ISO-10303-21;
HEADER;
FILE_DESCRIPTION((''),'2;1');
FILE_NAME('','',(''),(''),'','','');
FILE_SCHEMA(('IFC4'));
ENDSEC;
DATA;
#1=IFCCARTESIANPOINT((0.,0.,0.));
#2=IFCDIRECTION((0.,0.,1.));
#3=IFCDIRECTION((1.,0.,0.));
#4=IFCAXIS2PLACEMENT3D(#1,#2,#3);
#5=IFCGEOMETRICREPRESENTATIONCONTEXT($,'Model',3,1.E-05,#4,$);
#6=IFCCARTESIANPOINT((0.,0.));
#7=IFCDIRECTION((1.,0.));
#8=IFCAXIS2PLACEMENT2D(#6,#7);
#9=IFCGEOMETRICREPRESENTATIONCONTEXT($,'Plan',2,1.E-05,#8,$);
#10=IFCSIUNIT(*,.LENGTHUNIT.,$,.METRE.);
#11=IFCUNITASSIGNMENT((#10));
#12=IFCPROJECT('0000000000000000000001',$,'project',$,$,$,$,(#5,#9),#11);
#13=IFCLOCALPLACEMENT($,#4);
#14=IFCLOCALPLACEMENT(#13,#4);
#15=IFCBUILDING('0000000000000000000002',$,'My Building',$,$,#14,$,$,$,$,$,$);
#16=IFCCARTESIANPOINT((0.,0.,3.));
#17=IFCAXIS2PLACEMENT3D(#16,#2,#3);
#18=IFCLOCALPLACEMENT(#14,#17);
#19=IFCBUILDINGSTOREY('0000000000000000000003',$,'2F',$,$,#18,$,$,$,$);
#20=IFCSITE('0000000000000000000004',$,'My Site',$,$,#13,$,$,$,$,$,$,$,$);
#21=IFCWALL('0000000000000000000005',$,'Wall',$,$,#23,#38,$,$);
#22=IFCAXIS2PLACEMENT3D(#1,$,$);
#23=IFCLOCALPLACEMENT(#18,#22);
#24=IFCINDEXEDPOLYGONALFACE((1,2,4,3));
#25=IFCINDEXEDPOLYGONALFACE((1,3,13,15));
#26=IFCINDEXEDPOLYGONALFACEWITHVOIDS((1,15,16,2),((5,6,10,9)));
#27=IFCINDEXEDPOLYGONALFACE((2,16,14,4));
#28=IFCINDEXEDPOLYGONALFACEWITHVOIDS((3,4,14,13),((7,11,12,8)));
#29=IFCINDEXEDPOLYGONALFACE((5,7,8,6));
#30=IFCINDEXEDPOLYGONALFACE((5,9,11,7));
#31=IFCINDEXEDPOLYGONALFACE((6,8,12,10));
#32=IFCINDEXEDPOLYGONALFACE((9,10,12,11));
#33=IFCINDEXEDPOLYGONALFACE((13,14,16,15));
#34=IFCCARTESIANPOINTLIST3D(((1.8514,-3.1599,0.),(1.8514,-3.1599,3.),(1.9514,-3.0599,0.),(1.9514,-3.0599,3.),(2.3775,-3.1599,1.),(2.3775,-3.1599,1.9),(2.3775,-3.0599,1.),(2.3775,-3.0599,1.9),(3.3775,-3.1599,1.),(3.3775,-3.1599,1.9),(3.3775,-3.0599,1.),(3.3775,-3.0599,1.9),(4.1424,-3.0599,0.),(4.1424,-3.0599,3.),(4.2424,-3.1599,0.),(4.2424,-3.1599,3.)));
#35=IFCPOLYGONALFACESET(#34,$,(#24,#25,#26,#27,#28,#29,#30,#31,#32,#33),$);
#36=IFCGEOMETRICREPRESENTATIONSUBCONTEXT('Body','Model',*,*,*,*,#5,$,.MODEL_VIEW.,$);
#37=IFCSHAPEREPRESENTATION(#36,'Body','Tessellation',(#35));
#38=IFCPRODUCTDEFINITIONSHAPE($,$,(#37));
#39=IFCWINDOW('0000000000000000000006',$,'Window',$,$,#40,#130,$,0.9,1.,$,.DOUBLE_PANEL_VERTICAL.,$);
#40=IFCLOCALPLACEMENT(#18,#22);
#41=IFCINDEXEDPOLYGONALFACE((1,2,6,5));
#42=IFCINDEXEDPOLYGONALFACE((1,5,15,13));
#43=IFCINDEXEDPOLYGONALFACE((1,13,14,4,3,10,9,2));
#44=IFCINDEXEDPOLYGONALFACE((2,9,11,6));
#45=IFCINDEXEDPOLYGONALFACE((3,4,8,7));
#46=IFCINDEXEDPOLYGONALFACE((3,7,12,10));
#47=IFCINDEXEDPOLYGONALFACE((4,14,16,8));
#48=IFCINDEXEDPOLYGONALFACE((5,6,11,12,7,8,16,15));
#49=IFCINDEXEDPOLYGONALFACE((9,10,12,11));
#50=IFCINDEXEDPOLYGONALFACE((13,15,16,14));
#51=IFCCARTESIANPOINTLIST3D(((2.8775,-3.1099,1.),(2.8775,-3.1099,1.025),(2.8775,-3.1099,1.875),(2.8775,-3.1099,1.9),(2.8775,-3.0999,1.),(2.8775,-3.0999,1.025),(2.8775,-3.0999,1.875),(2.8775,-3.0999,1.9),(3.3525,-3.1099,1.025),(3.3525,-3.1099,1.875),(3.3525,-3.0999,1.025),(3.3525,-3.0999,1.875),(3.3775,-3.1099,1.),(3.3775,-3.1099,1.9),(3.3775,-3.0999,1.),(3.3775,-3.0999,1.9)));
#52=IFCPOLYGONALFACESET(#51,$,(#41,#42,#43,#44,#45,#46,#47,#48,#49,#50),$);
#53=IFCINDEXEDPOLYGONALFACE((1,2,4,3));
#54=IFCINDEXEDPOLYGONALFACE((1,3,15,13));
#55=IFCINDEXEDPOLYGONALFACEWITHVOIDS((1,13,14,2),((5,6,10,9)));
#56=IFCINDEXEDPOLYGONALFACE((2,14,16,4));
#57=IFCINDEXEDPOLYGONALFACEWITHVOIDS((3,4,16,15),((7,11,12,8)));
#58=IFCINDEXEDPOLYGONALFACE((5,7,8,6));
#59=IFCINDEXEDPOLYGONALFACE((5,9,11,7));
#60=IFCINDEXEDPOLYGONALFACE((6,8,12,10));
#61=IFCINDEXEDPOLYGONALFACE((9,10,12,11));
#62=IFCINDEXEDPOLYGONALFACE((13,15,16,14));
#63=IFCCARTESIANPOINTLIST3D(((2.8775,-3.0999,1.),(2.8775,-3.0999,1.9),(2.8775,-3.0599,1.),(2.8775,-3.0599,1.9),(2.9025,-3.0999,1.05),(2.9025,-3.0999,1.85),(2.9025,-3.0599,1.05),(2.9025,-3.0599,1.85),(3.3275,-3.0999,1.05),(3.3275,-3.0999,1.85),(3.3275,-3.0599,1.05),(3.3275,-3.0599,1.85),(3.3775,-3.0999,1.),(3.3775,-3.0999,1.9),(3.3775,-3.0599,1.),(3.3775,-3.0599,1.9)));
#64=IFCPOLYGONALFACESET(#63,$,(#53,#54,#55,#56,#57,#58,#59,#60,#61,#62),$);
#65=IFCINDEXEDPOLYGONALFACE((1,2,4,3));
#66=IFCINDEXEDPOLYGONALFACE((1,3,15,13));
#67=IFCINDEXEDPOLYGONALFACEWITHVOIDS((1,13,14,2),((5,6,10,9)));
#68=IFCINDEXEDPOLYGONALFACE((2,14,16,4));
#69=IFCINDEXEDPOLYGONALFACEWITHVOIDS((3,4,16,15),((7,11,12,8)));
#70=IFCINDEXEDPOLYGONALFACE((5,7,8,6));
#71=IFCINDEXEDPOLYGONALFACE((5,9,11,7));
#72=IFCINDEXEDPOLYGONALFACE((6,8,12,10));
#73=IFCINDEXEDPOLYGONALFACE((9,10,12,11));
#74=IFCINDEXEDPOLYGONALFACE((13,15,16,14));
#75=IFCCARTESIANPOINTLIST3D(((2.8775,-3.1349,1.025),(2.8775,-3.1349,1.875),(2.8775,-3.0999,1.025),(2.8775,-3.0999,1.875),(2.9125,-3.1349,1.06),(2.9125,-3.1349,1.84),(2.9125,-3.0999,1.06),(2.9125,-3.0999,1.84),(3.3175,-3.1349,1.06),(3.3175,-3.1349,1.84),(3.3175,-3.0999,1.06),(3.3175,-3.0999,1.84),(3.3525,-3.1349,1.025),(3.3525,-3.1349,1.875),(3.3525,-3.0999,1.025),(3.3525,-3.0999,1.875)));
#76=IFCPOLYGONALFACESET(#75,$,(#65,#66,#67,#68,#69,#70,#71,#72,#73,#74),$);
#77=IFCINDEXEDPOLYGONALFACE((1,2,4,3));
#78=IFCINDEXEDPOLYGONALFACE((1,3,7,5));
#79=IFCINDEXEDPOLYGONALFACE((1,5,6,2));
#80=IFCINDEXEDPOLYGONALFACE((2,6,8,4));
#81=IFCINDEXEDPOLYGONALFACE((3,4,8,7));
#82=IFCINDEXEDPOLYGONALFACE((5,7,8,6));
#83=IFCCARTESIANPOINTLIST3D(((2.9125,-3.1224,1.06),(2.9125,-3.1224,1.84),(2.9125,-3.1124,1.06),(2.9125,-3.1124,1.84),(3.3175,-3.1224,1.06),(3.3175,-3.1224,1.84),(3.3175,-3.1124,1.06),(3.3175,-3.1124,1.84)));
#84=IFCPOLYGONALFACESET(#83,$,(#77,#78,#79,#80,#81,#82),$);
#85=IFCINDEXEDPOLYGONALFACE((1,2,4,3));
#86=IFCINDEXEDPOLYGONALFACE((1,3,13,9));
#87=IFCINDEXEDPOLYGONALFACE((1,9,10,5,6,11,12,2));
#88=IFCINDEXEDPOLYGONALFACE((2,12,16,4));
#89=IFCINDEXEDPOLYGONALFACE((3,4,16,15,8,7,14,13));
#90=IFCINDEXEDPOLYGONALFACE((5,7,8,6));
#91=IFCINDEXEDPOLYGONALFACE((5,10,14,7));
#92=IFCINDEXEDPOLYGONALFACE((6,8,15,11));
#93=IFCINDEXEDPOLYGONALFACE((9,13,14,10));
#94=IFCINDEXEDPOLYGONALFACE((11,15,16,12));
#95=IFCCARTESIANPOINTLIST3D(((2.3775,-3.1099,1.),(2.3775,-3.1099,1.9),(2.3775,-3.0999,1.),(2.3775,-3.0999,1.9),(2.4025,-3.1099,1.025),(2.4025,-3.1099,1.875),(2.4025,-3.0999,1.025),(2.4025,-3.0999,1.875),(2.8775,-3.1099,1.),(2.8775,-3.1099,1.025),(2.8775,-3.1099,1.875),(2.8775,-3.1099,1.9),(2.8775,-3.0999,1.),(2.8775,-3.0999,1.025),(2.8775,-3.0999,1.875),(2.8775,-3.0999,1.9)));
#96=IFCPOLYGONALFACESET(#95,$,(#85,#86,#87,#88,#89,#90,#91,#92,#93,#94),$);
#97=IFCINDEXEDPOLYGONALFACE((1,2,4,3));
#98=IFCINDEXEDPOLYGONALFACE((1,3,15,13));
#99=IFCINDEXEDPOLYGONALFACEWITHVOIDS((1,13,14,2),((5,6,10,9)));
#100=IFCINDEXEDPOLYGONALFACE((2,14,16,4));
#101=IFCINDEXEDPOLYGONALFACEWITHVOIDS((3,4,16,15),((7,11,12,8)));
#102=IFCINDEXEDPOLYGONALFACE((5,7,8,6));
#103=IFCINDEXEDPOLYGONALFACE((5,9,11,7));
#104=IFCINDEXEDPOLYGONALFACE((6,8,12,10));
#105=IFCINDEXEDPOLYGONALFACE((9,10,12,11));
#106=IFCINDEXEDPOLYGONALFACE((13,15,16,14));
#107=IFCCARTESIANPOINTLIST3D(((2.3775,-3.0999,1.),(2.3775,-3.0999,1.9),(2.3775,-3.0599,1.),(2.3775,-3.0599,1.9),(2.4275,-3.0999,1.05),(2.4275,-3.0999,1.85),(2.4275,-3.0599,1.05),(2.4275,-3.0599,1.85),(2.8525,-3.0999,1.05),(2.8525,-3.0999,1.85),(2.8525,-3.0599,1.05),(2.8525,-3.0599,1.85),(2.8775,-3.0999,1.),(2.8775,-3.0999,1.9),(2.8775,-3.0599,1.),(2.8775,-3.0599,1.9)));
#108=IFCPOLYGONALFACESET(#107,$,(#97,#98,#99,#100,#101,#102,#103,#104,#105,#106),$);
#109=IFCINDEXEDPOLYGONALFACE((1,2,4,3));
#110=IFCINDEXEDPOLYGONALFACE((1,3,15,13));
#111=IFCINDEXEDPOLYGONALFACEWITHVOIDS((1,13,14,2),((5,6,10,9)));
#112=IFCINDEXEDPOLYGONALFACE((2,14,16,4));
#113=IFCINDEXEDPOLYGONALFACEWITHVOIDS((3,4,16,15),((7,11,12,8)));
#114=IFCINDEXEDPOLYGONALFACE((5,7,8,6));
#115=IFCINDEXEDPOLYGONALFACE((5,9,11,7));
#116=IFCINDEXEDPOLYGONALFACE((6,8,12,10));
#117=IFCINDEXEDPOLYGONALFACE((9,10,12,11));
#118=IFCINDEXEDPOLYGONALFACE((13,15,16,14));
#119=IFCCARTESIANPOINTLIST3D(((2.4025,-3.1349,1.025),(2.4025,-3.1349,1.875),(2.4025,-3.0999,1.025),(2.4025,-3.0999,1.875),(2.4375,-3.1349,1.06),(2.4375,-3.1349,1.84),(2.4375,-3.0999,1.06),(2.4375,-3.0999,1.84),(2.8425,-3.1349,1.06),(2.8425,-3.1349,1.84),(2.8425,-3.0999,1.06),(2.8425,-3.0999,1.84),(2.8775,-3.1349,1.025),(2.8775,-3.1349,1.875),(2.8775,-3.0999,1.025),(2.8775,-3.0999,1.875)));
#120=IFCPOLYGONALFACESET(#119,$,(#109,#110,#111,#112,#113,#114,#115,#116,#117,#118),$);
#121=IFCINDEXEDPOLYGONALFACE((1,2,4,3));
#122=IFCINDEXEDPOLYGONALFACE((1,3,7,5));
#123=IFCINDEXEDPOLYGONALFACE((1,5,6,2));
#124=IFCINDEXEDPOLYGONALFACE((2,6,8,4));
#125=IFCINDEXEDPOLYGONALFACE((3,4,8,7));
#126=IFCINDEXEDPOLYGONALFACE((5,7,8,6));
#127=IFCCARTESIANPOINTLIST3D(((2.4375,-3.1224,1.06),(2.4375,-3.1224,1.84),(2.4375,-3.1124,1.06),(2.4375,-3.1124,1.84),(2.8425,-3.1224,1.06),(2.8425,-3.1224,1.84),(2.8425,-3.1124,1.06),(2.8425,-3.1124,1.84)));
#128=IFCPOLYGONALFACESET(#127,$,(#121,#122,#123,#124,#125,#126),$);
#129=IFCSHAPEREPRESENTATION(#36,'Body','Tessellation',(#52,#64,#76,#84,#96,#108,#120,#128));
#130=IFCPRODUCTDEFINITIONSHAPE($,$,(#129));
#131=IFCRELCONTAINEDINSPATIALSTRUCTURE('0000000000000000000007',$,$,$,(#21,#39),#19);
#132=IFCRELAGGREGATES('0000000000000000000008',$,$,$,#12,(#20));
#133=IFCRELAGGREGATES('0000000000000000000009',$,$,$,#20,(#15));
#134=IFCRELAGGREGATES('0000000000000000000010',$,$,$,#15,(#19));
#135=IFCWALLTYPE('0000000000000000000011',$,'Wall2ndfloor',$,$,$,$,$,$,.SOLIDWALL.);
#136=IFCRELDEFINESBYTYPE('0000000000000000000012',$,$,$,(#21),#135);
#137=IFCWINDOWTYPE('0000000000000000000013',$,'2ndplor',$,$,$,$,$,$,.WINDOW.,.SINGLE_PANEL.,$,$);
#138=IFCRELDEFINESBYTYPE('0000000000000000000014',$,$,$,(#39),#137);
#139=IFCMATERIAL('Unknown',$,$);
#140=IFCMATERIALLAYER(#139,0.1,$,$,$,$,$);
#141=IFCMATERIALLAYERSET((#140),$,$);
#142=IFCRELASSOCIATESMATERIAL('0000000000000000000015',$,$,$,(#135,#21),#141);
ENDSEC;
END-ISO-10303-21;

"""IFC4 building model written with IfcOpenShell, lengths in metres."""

from ifc_helpers import new_model, entity, si_unit, frame, origin_with_axes, origin_2d_with_axis, place, context, subcontext, project, spatial, line, indexed_curve, outline, extrude, shape, source, transform, mapped, material, layer, layer_set, layer_usage, type_object, type_shapes, element, fill, save


model = new_model("IFC4")

# Units and contexts
model_context = context("Model", 3, precision=1e-05, world=origin_with_axes())
plan_context = context("Plan", 2, precision=1e-05, world=origin_2d_with_axis())
body_context_1 = subcontext(model_context, "Body", "Model", "MODEL_VIEW")
body_context_2 = subcontext(plan_context, "Body", "Plan", "PLAN_VIEW")
ifc_project = project(units=[si_unit("LENGTHUNIT", "METRE")], contexts=[model_context, plan_context])

# Site, building, storey
site_placement = place(None, origin_with_axes())
site = spatial("IfcSite", under=ifc_project, at=site_placement, Name="My Site")
building_placement = place(site_placement, origin_with_axes())
building = spatial("IfcBuilding", under=site, at=building_placement, Name="My Building")
storey_placement = place(building_placement, frame((0.0, 0.0, 3.0), z_axis=(0.0, 0.0, 1.0), x_axis=(1.0, 0.0, 0.0)))
storey = spatial("IfcBuildingStorey", under=building, at=storey_placement, Name="2F")

# Shared definitions
ifc_material = material(Name="Unknown")

# Shared definitions
ifc_layer_1 = layer(ifc_material, 0.1)
ifc_layer_set_1 = layer_set([ifc_layer_1])
wall_type = type_object("IfcWallType", Name="Wall2ndfloor", PredefinedType="SOLIDWALL", material=ifc_layer_set_1)

# Wall, opening, window
ifc_layer_usage_1 = layer_usage(ifc_layer_set_1, "AXIS2", "POSITIVE", 0.0)
wall_1_placement = place(storey_placement, frame((1.8514, -3.1599, 0.0), z_axis=(0.0, 0.0, 1.0), x_axis=(1.0, 0.0, 0.0)))
wall_1 = element("IfcWall", 1, at=wall_1_placement, inside=storey, type_object=wall_type, material=ifc_layer_usage_1, Name="Wall", context=body_context_1, shape_type="SweptSolid", body=[
    extrude(outline(indexed_curve([(0.0, 0.0), (0.1, 0.1), (2.291, 0.1), (2.391, 0.0)], segments=[line(1, 2, 3, 4, 1)])), origin_with_axes(), (0.0, 0.0, 1.0), 3.0),
])
shared_shape_1 = source(origin_with_axes(), body_context_1, "Body", "SweptSolid", [
    extrude(outline(indexed_curve([(0.0, 0.0), (1.0, 0.0), (1.0, 0.9), (0.0, 0.9)], segments=[line(1, 2, 3, 4, 1)])), frame((0.0, -0.6, 0.0), z_axis=(0.0, -1.0, 0.0), x_axis=(1.0, 0.0, 0.0)), (0.0, 0.0, -1.0), 1.2),
])
opening_1_placement = place(wall_1_placement, frame((1.5262, 0.15, 1.0), z_axis=(0.0, 0.0, 1.0), x_axis=(-1.0, 0.000001, 0.0)))
opening_1 = element("IfcOpeningElement", 2, at=opening_1_placement, cuts=wall_1, PredefinedType="OPENING", context=body_context_1, shape_type="MappedRepresentation", body=[
    mapped(shared_shape_1, transform((0.0, 0.0, 0.0), x_axis=(1.0, 0.0, 0.0), y_axis=(0.0, 1.0, 0.0), z_axis=(0.0, 0.0, 1.0), scale=1.0)),
])
window_type_1 = type_object("IfcWindowType", Name="2ndplor", PartitioningType="SINGLE_PANEL", PredefinedType="WINDOW")
shared_shape_2 = source(origin_with_axes(), body_context_1, "Body", "SweptSolid", [
    extrude(outline(indexed_curve([(0.5, 0.0), (0.0, 0.0), (0.0, 0.9), (0.5, 0.9), (0.5, 0.875), (0.025, 0.875), (0.025, 0.025), (0.5, 0.025)], segments=[line(1, 2, 3, 4, 5, 6, 7, 8, 1)])), frame((0.0, 0.09, 0.0), z_axis=(0.0, -1.0, 0.0), x_axis=(1.0, 0.0, 0.0)), (0.0, 0.0, -1.0), 0.01),
    extrude(outline(indexed_curve([(0.0, 0.0), (0.5, 0.0), (0.5, 0.9), (0.0, 0.9)], segments=[line(1, 2, 3, 4, 1)]), holes=[indexed_curve([(0.05, 0.05), (0.475, 0.05), (0.475, 0.85), (0.05, 0.85)], segments=[line(1, 2, 3, 4, 1)])]), frame((0.0, 0.05, 0.0), z_axis=(0.0, -1.0, 0.0), x_axis=(1.0, 0.0, 0.0)), (0.0, 0.0, -1.0), 0.04),
    extrude(outline(indexed_curve([(0.0, 0.0), (0.475, 0.0), (0.475, 0.85), (0.0, 0.85)], segments=[line(1, 2, 3, 4, 1)]), holes=[indexed_curve([(0.035, 0.035), (0.44, 0.035), (0.44, 0.815), (0.035, 0.815)], segments=[line(1, 2, 3, 4, 1)])]), frame((0.025, 0.09, 0.025), z_axis=(0.0, -1.0, 0.0), x_axis=(1.0, 0.0, 0.0)), (0.0, 0.0, -1.0), 0.035),
    extrude(outline(indexed_curve([(0.035, 0.035), (0.44, 0.035), (0.44, 0.815), (0.035, 0.815)], segments=[line(1, 2, 3, 4, 1)])), frame((0.025, 0.1025, 0.025), z_axis=(0.0, -1.0, 0.0), x_axis=(1.0, 0.0, 0.0)), (0.0, 0.0, -1.0), 0.01),
    extrude(outline(indexed_curve([(0.0, 0.9), (0.5, 0.9), (0.5, 0.0), (0.0, 0.0), (0.0, 0.025), (0.475, 0.025), (0.475, 0.875), (0.0, 0.875)], segments=[line(1, 2, 3, 4, 5, 6, 7, 8, 1)])), frame((0.5, 0.09, 0.0), z_axis=(0.0, -1.0, 0.0), x_axis=(1.0, 0.0, 0.0)), (0.0, 0.0, -1.0), 0.01),
    extrude(outline(indexed_curve([(0.0, 0.0), (0.5, 0.0), (0.5, 0.9), (0.0, 0.9)], segments=[line(1, 2, 3, 4, 1)]), holes=[indexed_curve([(0.025, 0.05), (0.45, 0.05), (0.45, 0.85), (0.025, 0.85)], segments=[line(1, 2, 3, 4, 1)])]), frame((0.5, 0.05, 0.0), z_axis=(0.0, -1.0, 0.0), x_axis=(1.0, 0.0, 0.0)), (0.0, 0.0, -1.0), 0.04),
    extrude(outline(indexed_curve([(0.0, 0.0), (0.475, 0.0), (0.475, 0.85), (0.0, 0.85)], segments=[line(1, 2, 3, 4, 1)]), holes=[indexed_curve([(0.035, 0.035), (0.44, 0.035), (0.44, 0.815), (0.035, 0.815)], segments=[line(1, 2, 3, 4, 1)])]), frame((0.5, 0.09, 0.025), z_axis=(0.0, -1.0, 0.0), x_axis=(1.0, 0.0, 0.0)), (0.0, 0.0, -1.0), 0.035),
    extrude(outline(indexed_curve([(0.035, 0.035), (0.44, 0.035), (0.44, 0.815), (0.035, 0.815)], segments=[line(1, 2, 3, 4, 1)])), frame((0.5, 0.1025, 0.025), z_axis=(0.0, -1.0, 0.0), x_axis=(1.0, 0.0, 0.0)), (0.0, 0.0, -1.0), 0.01),
])
shared_shape_3 = source(origin_with_axes(), body_context_2, "Body", "Curve2D", [
    entity("IfcIndexedPolyCurve", entity("IfcCartesianPointList2D", [[0.05, 0.05], [0.475, 0.05]])),
    entity("IfcIndexedPolyCurve", entity("IfcCartesianPointList2D", [[0.0, 0.1], [0.025, 0.1], [0.025, 0.09], [0.05, 0.09], [0.05, 0.05], [0.0, 0.05]]), [entity("IfcLineIndex", [1, 2, 3, 4, 5, 6, 1])]),
    entity("IfcIndexedPolyCurve", entity("IfcCartesianPointList2D", [[0.5, 0.1], [0.5, 0.1], [0.5, 0.09], [0.475, 0.09], [0.475, 0.05], [0.5, 0.05]])),
    entity("IfcIndexedPolyCurve", entity("IfcCartesianPointList2D", [[0.025, 0.09], [0.06, 0.09], [0.06, 0.125], [0.025, 0.125]]), [entity("IfcLineIndex", [1, 2, 3, 4, 1])]),
    entity("IfcIndexedPolyCurve", entity("IfcCartesianPointList2D", [[0.5, 0.09], [0.465, 0.09], [0.465, 0.125], [0.5, 0.125]]), [entity("IfcLineIndex", [1, 2, 3, 4, 1])]),
    entity("IfcIndexedPolyCurve", entity("IfcCartesianPointList2D", [[0.06, 0.09], [0.465, 0.09]])),
    entity("IfcIndexedPolyCurve", entity("IfcCartesianPointList2D", [[0.06, 0.125], [0.465, 0.125]])),
    entity("IfcIndexedPolyCurve", entity("IfcCartesianPointList2D", [[0.06, 0.1075], [0.465, 0.1075]])),
    entity("IfcIndexedPolyCurve", entity("IfcCartesianPointList2D", [[0.525, 0.05], [0.95, 0.05]])),
    entity("IfcIndexedPolyCurve", entity("IfcCartesianPointList2D", [[0.5, 0.1], [0.5, 0.1], [0.5, 0.09], [0.525, 0.09], [0.525, 0.05], [0.5, 0.05]])),
    entity("IfcIndexedPolyCurve", entity("IfcCartesianPointList2D", [[1.0, 0.1], [0.975, 0.1], [0.975, 0.09], [0.95, 0.09], [0.95, 0.05], [1.0, 0.05]]), [entity("IfcLineIndex", [1, 2, 3, 4, 5, 6, 1])]),
    entity("IfcIndexedPolyCurve", entity("IfcCartesianPointList2D", [[0.5, 0.09], [0.535, 0.09], [0.535, 0.125], [0.5, 0.125]]), [entity("IfcLineIndex", [1, 2, 3, 4, 1])]),
    entity("IfcIndexedPolyCurve", entity("IfcCartesianPointList2D", [[0.975, 0.09], [0.94, 0.09], [0.94, 0.125], [0.975, 0.125]]), [entity("IfcLineIndex", [1, 2, 3, 4, 1])]),
    entity("IfcIndexedPolyCurve", entity("IfcCartesianPointList2D", [[0.535, 0.09], [0.94, 0.09]])),
    entity("IfcIndexedPolyCurve", entity("IfcCartesianPointList2D", [[0.535, 0.125], [0.94, 0.125]])),
    entity("IfcIndexedPolyCurve", entity("IfcCartesianPointList2D", [[0.535, 0.1075], [0.94, 0.1075]])),
])
type_shapes(window_type_1, [shared_shape_2, shared_shape_3])
window_1_placement = place(opening_1_placement, origin_with_axes())
window_1 = element("IfcWindow", 3, at=window_1_placement, inside=storey, type_object=window_type_1, Name="Window", OverallHeight=0.9, OverallWidth=1.0, PartitioningType="DOUBLE_PANEL_VERTICAL", shapes=[
    shape(body_context_1, "Body", "MappedRepresentation", [mapped(shared_shape_2, transform((0.0, 0.0, 0.0), x_axis=(1.0, 0.0, 0.0), y_axis=(0.0, 1.0, 0.0), z_axis=(0.0, 0.0, 1.0), scale=1.0))]),
    shape(body_context_2, "Body", "MappedRepresentation", [mapped(shared_shape_3, transform((0.0, 0.0, 0.0), x_axis=(1.0, 0.0, 0.0), y_axis=(0.0, 1.0, 0.0), z_axis=(0.0, 0.0, 1.0), scale=1.0))]),
])
fill(opening_1, window_1)

save(model, "model.ifc")
